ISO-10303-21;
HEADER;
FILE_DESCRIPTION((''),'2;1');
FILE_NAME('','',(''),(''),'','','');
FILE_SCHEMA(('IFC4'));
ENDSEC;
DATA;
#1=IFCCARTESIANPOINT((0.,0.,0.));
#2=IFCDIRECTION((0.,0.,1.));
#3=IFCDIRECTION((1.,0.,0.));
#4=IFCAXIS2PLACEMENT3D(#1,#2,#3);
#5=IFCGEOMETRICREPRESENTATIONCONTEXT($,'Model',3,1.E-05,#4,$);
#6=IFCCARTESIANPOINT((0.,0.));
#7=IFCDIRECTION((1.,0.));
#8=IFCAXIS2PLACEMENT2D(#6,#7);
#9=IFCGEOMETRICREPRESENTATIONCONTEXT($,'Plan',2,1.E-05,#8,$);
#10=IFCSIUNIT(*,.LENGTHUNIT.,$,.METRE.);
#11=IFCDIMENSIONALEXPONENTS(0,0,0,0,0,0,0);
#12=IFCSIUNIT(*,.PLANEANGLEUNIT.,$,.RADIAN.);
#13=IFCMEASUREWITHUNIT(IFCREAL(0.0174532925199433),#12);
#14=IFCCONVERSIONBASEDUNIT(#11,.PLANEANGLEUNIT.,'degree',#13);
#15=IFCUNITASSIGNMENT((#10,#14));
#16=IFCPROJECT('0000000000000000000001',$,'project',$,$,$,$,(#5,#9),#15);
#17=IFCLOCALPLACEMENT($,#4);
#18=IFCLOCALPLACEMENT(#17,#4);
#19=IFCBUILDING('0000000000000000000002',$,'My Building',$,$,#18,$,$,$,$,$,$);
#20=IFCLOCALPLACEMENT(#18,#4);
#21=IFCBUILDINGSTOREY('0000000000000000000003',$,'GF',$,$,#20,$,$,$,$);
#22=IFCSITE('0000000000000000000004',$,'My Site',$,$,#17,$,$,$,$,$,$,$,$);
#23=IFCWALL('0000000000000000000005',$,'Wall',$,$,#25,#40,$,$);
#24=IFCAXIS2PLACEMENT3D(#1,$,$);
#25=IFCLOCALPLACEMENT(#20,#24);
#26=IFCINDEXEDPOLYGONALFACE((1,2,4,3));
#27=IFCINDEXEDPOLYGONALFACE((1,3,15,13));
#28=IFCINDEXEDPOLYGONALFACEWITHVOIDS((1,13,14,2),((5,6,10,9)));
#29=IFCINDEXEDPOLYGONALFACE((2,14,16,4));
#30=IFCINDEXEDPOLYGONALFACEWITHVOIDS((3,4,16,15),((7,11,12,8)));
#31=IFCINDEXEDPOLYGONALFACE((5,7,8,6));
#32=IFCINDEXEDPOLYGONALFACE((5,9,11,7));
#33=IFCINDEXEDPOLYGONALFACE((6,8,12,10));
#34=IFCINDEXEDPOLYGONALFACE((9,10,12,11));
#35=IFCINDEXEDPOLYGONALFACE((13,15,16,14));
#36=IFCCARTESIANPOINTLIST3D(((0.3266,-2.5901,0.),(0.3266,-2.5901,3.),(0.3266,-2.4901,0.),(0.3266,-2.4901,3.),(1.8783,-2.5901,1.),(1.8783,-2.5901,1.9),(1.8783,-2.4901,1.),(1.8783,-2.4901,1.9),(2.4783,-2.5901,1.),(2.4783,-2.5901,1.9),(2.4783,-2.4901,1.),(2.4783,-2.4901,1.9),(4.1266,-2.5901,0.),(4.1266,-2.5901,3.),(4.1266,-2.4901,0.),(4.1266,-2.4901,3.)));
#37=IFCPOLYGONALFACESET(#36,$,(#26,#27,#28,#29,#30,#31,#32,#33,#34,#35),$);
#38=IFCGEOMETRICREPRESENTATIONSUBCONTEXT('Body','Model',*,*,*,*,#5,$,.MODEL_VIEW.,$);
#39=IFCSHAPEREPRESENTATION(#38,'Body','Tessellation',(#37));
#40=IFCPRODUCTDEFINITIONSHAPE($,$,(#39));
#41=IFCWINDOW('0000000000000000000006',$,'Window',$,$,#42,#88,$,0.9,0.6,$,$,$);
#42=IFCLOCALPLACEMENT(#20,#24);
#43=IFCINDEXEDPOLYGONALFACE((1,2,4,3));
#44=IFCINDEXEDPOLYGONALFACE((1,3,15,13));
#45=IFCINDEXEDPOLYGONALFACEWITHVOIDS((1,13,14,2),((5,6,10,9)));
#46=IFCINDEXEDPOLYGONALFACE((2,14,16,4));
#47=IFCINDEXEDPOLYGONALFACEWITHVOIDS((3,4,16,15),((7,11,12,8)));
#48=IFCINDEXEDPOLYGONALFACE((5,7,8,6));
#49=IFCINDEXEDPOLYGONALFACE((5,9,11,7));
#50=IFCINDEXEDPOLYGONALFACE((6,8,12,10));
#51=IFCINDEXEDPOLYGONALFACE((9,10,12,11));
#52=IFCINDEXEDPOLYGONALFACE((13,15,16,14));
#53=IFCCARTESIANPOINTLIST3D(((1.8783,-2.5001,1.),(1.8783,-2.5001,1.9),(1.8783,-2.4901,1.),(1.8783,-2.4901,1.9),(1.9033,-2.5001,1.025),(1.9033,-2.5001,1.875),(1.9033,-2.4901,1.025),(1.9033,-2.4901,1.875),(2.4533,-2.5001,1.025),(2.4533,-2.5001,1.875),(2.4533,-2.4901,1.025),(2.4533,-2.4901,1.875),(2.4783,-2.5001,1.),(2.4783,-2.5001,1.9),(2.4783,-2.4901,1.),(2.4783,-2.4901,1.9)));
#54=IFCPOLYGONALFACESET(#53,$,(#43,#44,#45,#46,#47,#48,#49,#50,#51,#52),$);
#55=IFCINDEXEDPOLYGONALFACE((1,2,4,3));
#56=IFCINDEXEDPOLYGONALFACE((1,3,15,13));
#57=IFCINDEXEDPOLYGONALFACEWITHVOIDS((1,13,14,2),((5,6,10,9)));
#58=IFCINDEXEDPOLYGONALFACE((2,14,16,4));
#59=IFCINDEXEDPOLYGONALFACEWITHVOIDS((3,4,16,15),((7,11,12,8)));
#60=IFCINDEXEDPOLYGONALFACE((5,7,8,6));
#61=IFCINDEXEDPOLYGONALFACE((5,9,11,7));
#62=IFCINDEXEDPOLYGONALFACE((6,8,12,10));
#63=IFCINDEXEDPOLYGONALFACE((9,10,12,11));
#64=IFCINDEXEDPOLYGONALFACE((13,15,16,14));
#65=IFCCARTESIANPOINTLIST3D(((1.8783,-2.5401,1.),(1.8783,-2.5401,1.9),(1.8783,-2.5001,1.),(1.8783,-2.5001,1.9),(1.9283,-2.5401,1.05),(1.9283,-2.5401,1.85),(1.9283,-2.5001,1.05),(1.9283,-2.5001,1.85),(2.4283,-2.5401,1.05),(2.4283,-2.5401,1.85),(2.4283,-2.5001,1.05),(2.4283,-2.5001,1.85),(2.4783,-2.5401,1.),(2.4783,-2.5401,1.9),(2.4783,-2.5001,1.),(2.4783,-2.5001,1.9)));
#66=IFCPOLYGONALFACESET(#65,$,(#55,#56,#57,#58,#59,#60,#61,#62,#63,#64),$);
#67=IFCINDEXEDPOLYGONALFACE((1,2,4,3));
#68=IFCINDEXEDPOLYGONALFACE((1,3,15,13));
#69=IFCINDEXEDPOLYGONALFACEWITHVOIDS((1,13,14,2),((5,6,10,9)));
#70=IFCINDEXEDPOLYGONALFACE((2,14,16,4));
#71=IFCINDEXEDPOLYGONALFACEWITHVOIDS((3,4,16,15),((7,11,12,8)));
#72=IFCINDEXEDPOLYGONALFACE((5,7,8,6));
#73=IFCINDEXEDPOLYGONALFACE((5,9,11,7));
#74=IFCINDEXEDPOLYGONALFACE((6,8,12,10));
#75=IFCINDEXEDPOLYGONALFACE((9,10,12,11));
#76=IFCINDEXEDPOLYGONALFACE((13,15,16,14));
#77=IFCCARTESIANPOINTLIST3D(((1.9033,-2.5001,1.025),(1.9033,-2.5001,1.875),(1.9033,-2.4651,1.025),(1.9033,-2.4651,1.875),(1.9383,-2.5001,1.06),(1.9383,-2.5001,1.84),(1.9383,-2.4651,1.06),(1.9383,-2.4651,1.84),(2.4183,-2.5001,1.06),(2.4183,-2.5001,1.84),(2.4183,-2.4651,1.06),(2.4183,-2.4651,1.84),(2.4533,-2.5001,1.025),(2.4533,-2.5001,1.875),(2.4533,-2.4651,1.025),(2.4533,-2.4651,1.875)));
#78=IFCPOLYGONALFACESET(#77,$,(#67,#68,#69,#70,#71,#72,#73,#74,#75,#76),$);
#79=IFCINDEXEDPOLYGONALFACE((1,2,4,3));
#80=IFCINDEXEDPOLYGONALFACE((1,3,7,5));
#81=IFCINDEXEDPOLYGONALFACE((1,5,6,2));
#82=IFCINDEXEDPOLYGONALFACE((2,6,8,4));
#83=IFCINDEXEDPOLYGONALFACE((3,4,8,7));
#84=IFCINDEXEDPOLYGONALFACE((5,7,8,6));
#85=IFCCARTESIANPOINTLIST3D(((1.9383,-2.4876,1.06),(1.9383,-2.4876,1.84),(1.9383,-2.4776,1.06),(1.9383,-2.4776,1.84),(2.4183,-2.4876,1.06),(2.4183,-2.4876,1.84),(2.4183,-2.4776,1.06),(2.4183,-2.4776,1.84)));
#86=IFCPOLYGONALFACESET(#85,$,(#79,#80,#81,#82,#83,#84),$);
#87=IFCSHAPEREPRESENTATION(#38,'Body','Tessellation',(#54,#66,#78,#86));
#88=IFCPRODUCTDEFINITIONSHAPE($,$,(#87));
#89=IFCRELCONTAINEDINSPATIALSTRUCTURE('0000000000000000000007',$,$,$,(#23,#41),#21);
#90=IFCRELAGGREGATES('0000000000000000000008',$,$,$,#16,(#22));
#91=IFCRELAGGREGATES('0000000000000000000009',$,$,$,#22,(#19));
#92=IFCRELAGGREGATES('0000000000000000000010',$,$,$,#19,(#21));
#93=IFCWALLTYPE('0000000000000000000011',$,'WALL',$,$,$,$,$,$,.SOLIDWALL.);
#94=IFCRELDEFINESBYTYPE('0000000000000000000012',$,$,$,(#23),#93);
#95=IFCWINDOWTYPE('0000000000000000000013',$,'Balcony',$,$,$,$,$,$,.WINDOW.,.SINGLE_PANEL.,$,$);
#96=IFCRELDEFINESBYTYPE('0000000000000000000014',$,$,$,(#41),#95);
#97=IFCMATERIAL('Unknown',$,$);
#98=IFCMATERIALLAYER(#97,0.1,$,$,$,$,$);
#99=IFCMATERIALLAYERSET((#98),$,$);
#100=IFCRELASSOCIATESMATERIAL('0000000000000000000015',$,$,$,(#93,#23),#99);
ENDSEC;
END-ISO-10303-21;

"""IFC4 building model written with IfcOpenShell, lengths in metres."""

from ifc_helpers import new_model, entity, si_unit, converted_unit, frame, origin_with_axes, origin_2d_with_axis, place, context, subcontext, project, spatial, line, indexed_curve, outline, extrude, shape, source, transform, mapped, material, layer, layer_set, layer_usage, type_object, type_shapes, element, fill, save


model = new_model("IFC4")

# Units and contexts
model_context = context("Model", 3, precision=1e-05, world=origin_with_axes())
plan_context = context("Plan", 2, precision=1e-05, world=origin_2d_with_axis())
body_context_1 = subcontext(model_context, "Body", "Model", "MODEL_VIEW")
body_context_2 = subcontext(plan_context, "Body", "Plan", "PLAN_VIEW")
ifc_project = project(units=[si_unit("LENGTHUNIT", "METRE"), converted_unit("PLANEANGLEUNIT", "degree", entity("IfcReal", 0.0174532925199433), si_unit("PLANEANGLEUNIT", "RADIAN"), dimensions=[0, 0, 0, 0, 0, 0, 0])], contexts=[model_context, plan_context])

# Site, building, storey
site_placement = place(None, origin_with_axes())
site = spatial("IfcSite", under=ifc_project, at=site_placement, Name="My Site")
building_placement = place(site_placement, origin_with_axes())
building = spatial("IfcBuilding", under=site, at=building_placement, Name="My Building")
storey_placement = place(building_placement, origin_with_axes())
storey = spatial("IfcBuildingStorey", under=building, at=storey_placement, Name="GF")

# Shared definitions
ifc_material_1 = material(Name="Unknown")

# Shared definitions
ifc_layer_1 = layer(ifc_material_1, 0.1)
ifc_layer_set_1 = layer_set([ifc_layer_1])
wall_type = type_object("IfcWallType", Name="WALL", PredefinedType="SOLIDWALL", material=ifc_layer_set_1)

# Wall, opening, window
ifc_layer_usage_1 = layer_usage(ifc_layer_set_1, "AXIS2", "POSITIVE", 0.0)
wall_1_placement = place(storey_placement, frame((0.3266, -2.5901, 0.0), z_axis=(0.0, 0.0, 1.0), x_axis=(1.0, 0.0, 0.0)))
wall_1 = element("IfcWall", 1, at=wall_1_placement, inside=storey, type_object=wall_type, material=ifc_layer_usage_1, Name="Wall", context=body_context_1, shape_type="SweptSolid", body=[
    extrude(outline(indexed_curve([(0.0, 0.0), (0.0, 0.1), (3.8, 0.1), (3.8, 0.0)], segments=[line(1, 2, 3, 4, 1)])), origin_with_axes(), (0.0, 0.0, 1.0), 3.0),
])
shared_shape_1 = source(origin_with_axes(), body_context_1, "Body", "SweptSolid", [
    extrude(outline(indexed_curve([(0.0, 0.0), (0.6, 0.0), (0.6, 0.9), (0.0, 0.9)], segments=[line(1, 2, 3, 4, 1)])), frame((0.0, -0.6, 0.0), z_axis=(0.0, -1.0, 0.0), x_axis=(1.0, 0.0, 0.0)), (0.0, 0.0, -1.0), 1.2),
])
opening_1_placement = place(wall_1_placement, frame((1.5517, 0.0, 1.0), z_axis=(0.0, 0.0, 1.0), x_axis=(1.0, 0.0, 0.0)))
opening_1 = element("IfcOpeningElement", 2, at=opening_1_placement, cuts=wall_1, PredefinedType="OPENING", context=body_context_1, shape_type="MappedRepresentation", body=[
    mapped(shared_shape_1, transform((0.0, 0.0, 0.0), x_axis=(1.0, 0.0, 0.0), y_axis=(0.0, 1.0, 0.0), z_axis=(0.0, 0.0, 1.0), scale=1.0)),
])
window_type_1 = type_object("IfcWindowType", Name="Balcony", PartitioningType="SINGLE_PANEL", PredefinedType="WINDOW")
shared_shape_2 = source(origin_with_axes(), body_context_1, "Body", "SweptSolid", [
    extrude(outline(indexed_curve([(0.0, 0.0), (0.6, 0.0), (0.6, 0.9), (0.0, 0.9)], segments=[line(1, 2, 3, 4, 1)]), holes=[indexed_curve([(0.025, 0.025), (0.575, 0.025), (0.575, 0.875), (0.025, 0.875)], segments=[line(1, 2, 3, 4, 1)])]), frame((0.0, 0.09, 0.0), z_axis=(0.0, -1.0, 0.0), x_axis=(1.0, 0.0, 0.0)), (0.0, 0.0, -1.0), 0.01),
    extrude(outline(indexed_curve([(0.0, 0.0), (0.6, 0.0), (0.6, 0.9), (0.0, 0.9)], segments=[line(1, 2, 3, 4, 1)]), holes=[indexed_curve([(0.05, 0.05), (0.55, 0.05), (0.55, 0.85), (0.05, 0.85)], segments=[line(1, 2, 3, 4, 1)])]), frame((0.0, 0.05, 0.0), z_axis=(0.0, -1.0, 0.0), x_axis=(1.0, 0.0, 0.0)), (0.0, 0.0, -1.0), 0.04),
    extrude(outline(indexed_curve([(0.0, 0.0), (0.55, 0.0), (0.55, 0.85), (0.0, 0.85)], segments=[line(1, 2, 3, 4, 1)]), holes=[indexed_curve([(0.035, 0.035), (0.515, 0.035), (0.515, 0.815), (0.035, 0.815)], segments=[line(1, 2, 3, 4, 1)])]), frame((0.025, 0.09, 0.025), z_axis=(0.0, -1.0, 0.0), x_axis=(1.0, 0.0, 0.0)), (0.0, 0.0, -1.0), 0.035),
    extrude(outline(indexed_curve([(0.035, 0.035), (0.515, 0.035), (0.515, 0.815), (0.035, 0.815)], segments=[line(1, 2, 3, 4, 1)])), frame((0.025, 0.1025, 0.025), z_axis=(0.0, -1.0, 0.0), x_axis=(1.0, 0.0, 0.0)), (0.0, 0.0, -1.0), 0.01),
])
shared_shape_3 = source(origin_with_axes(), body_context_2, "Body", "Curve2D", [
    entity("IfcIndexedPolyCurve", entity("IfcCartesianPointList2D", [[0.05, 0.05], [0.55, 0.05]])),
    entity("IfcIndexedPolyCurve", entity("IfcCartesianPointList2D", [[0.0, 0.1], [0.025, 0.1], [0.025, 0.09], [0.05, 0.09], [0.05, 0.05], [0.0, 0.05]]), [entity("IfcLineIndex", [1, 2, 3, 4, 5, 6, 1])]),
    entity("IfcIndexedPolyCurve", entity("IfcCartesianPointList2D", [[0.6, 0.1], [0.575, 0.1], [0.575, 0.09], [0.55, 0.09], [0.55, 0.05], [0.6, 0.05]]), [entity("IfcLineIndex", [1, 2, 3, 4, 5, 6, 1])]),
    entity("IfcIndexedPolyCurve", entity("IfcCartesianPointList2D", [[0.025, 0.09], [0.06, 0.09], [0.06, 0.125], [0.025, 0.125]]), [entity("IfcLineIndex", [1, 2, 3, 4, 1])]),
    entity("IfcIndexedPolyCurve", entity("IfcCartesianPointList2D", [[0.575, 0.09], [0.54, 0.09], [0.54, 0.125], [0.575, 0.125]]), [entity("IfcLineIndex", [1, 2, 3, 4, 1])]),
    entity("IfcIndexedPolyCurve", entity("IfcCartesianPointList2D", [[0.06, 0.09], [0.54, 0.09]])),
    entity("IfcIndexedPolyCurve", entity("IfcCartesianPointList2D", [[0.06, 0.125], [0.54, 0.125]])),
    entity("IfcIndexedPolyCurve", entity("IfcCartesianPointList2D", [[0.06, 0.1075], [0.54, 0.1075]])),
])
type_shapes(window_type_1, [shared_shape_2, shared_shape_3])
window_1_placement = place(opening_1_placement, origin_with_axes())
window_1 = element("IfcWindow", 3, at=window_1_placement, inside=storey, type_object=window_type_1, Name="Window", OverallHeight=0.9, OverallWidth=0.6, shapes=[
    shape(body_context_1, "Body", "MappedRepresentation", [mapped(shared_shape_2, transform((0.0, 0.0, 0.0), x_axis=(1.0, 0.0, 0.0), y_axis=(0.0, 1.0, 0.0), z_axis=(0.0, 0.0, 1.0), scale=1.0))]),
    shape(body_context_2, "Body", "MappedRepresentation", [mapped(shared_shape_3, transform((0.0, 0.0, 0.0), x_axis=(1.0, 0.0, 0.0), y_axis=(0.0, 1.0, 0.0), z_axis=(0.0, 0.0, 1.0), scale=1.0))]),
])
fill(opening_1, window_1)

save(model, "model.ifc")
